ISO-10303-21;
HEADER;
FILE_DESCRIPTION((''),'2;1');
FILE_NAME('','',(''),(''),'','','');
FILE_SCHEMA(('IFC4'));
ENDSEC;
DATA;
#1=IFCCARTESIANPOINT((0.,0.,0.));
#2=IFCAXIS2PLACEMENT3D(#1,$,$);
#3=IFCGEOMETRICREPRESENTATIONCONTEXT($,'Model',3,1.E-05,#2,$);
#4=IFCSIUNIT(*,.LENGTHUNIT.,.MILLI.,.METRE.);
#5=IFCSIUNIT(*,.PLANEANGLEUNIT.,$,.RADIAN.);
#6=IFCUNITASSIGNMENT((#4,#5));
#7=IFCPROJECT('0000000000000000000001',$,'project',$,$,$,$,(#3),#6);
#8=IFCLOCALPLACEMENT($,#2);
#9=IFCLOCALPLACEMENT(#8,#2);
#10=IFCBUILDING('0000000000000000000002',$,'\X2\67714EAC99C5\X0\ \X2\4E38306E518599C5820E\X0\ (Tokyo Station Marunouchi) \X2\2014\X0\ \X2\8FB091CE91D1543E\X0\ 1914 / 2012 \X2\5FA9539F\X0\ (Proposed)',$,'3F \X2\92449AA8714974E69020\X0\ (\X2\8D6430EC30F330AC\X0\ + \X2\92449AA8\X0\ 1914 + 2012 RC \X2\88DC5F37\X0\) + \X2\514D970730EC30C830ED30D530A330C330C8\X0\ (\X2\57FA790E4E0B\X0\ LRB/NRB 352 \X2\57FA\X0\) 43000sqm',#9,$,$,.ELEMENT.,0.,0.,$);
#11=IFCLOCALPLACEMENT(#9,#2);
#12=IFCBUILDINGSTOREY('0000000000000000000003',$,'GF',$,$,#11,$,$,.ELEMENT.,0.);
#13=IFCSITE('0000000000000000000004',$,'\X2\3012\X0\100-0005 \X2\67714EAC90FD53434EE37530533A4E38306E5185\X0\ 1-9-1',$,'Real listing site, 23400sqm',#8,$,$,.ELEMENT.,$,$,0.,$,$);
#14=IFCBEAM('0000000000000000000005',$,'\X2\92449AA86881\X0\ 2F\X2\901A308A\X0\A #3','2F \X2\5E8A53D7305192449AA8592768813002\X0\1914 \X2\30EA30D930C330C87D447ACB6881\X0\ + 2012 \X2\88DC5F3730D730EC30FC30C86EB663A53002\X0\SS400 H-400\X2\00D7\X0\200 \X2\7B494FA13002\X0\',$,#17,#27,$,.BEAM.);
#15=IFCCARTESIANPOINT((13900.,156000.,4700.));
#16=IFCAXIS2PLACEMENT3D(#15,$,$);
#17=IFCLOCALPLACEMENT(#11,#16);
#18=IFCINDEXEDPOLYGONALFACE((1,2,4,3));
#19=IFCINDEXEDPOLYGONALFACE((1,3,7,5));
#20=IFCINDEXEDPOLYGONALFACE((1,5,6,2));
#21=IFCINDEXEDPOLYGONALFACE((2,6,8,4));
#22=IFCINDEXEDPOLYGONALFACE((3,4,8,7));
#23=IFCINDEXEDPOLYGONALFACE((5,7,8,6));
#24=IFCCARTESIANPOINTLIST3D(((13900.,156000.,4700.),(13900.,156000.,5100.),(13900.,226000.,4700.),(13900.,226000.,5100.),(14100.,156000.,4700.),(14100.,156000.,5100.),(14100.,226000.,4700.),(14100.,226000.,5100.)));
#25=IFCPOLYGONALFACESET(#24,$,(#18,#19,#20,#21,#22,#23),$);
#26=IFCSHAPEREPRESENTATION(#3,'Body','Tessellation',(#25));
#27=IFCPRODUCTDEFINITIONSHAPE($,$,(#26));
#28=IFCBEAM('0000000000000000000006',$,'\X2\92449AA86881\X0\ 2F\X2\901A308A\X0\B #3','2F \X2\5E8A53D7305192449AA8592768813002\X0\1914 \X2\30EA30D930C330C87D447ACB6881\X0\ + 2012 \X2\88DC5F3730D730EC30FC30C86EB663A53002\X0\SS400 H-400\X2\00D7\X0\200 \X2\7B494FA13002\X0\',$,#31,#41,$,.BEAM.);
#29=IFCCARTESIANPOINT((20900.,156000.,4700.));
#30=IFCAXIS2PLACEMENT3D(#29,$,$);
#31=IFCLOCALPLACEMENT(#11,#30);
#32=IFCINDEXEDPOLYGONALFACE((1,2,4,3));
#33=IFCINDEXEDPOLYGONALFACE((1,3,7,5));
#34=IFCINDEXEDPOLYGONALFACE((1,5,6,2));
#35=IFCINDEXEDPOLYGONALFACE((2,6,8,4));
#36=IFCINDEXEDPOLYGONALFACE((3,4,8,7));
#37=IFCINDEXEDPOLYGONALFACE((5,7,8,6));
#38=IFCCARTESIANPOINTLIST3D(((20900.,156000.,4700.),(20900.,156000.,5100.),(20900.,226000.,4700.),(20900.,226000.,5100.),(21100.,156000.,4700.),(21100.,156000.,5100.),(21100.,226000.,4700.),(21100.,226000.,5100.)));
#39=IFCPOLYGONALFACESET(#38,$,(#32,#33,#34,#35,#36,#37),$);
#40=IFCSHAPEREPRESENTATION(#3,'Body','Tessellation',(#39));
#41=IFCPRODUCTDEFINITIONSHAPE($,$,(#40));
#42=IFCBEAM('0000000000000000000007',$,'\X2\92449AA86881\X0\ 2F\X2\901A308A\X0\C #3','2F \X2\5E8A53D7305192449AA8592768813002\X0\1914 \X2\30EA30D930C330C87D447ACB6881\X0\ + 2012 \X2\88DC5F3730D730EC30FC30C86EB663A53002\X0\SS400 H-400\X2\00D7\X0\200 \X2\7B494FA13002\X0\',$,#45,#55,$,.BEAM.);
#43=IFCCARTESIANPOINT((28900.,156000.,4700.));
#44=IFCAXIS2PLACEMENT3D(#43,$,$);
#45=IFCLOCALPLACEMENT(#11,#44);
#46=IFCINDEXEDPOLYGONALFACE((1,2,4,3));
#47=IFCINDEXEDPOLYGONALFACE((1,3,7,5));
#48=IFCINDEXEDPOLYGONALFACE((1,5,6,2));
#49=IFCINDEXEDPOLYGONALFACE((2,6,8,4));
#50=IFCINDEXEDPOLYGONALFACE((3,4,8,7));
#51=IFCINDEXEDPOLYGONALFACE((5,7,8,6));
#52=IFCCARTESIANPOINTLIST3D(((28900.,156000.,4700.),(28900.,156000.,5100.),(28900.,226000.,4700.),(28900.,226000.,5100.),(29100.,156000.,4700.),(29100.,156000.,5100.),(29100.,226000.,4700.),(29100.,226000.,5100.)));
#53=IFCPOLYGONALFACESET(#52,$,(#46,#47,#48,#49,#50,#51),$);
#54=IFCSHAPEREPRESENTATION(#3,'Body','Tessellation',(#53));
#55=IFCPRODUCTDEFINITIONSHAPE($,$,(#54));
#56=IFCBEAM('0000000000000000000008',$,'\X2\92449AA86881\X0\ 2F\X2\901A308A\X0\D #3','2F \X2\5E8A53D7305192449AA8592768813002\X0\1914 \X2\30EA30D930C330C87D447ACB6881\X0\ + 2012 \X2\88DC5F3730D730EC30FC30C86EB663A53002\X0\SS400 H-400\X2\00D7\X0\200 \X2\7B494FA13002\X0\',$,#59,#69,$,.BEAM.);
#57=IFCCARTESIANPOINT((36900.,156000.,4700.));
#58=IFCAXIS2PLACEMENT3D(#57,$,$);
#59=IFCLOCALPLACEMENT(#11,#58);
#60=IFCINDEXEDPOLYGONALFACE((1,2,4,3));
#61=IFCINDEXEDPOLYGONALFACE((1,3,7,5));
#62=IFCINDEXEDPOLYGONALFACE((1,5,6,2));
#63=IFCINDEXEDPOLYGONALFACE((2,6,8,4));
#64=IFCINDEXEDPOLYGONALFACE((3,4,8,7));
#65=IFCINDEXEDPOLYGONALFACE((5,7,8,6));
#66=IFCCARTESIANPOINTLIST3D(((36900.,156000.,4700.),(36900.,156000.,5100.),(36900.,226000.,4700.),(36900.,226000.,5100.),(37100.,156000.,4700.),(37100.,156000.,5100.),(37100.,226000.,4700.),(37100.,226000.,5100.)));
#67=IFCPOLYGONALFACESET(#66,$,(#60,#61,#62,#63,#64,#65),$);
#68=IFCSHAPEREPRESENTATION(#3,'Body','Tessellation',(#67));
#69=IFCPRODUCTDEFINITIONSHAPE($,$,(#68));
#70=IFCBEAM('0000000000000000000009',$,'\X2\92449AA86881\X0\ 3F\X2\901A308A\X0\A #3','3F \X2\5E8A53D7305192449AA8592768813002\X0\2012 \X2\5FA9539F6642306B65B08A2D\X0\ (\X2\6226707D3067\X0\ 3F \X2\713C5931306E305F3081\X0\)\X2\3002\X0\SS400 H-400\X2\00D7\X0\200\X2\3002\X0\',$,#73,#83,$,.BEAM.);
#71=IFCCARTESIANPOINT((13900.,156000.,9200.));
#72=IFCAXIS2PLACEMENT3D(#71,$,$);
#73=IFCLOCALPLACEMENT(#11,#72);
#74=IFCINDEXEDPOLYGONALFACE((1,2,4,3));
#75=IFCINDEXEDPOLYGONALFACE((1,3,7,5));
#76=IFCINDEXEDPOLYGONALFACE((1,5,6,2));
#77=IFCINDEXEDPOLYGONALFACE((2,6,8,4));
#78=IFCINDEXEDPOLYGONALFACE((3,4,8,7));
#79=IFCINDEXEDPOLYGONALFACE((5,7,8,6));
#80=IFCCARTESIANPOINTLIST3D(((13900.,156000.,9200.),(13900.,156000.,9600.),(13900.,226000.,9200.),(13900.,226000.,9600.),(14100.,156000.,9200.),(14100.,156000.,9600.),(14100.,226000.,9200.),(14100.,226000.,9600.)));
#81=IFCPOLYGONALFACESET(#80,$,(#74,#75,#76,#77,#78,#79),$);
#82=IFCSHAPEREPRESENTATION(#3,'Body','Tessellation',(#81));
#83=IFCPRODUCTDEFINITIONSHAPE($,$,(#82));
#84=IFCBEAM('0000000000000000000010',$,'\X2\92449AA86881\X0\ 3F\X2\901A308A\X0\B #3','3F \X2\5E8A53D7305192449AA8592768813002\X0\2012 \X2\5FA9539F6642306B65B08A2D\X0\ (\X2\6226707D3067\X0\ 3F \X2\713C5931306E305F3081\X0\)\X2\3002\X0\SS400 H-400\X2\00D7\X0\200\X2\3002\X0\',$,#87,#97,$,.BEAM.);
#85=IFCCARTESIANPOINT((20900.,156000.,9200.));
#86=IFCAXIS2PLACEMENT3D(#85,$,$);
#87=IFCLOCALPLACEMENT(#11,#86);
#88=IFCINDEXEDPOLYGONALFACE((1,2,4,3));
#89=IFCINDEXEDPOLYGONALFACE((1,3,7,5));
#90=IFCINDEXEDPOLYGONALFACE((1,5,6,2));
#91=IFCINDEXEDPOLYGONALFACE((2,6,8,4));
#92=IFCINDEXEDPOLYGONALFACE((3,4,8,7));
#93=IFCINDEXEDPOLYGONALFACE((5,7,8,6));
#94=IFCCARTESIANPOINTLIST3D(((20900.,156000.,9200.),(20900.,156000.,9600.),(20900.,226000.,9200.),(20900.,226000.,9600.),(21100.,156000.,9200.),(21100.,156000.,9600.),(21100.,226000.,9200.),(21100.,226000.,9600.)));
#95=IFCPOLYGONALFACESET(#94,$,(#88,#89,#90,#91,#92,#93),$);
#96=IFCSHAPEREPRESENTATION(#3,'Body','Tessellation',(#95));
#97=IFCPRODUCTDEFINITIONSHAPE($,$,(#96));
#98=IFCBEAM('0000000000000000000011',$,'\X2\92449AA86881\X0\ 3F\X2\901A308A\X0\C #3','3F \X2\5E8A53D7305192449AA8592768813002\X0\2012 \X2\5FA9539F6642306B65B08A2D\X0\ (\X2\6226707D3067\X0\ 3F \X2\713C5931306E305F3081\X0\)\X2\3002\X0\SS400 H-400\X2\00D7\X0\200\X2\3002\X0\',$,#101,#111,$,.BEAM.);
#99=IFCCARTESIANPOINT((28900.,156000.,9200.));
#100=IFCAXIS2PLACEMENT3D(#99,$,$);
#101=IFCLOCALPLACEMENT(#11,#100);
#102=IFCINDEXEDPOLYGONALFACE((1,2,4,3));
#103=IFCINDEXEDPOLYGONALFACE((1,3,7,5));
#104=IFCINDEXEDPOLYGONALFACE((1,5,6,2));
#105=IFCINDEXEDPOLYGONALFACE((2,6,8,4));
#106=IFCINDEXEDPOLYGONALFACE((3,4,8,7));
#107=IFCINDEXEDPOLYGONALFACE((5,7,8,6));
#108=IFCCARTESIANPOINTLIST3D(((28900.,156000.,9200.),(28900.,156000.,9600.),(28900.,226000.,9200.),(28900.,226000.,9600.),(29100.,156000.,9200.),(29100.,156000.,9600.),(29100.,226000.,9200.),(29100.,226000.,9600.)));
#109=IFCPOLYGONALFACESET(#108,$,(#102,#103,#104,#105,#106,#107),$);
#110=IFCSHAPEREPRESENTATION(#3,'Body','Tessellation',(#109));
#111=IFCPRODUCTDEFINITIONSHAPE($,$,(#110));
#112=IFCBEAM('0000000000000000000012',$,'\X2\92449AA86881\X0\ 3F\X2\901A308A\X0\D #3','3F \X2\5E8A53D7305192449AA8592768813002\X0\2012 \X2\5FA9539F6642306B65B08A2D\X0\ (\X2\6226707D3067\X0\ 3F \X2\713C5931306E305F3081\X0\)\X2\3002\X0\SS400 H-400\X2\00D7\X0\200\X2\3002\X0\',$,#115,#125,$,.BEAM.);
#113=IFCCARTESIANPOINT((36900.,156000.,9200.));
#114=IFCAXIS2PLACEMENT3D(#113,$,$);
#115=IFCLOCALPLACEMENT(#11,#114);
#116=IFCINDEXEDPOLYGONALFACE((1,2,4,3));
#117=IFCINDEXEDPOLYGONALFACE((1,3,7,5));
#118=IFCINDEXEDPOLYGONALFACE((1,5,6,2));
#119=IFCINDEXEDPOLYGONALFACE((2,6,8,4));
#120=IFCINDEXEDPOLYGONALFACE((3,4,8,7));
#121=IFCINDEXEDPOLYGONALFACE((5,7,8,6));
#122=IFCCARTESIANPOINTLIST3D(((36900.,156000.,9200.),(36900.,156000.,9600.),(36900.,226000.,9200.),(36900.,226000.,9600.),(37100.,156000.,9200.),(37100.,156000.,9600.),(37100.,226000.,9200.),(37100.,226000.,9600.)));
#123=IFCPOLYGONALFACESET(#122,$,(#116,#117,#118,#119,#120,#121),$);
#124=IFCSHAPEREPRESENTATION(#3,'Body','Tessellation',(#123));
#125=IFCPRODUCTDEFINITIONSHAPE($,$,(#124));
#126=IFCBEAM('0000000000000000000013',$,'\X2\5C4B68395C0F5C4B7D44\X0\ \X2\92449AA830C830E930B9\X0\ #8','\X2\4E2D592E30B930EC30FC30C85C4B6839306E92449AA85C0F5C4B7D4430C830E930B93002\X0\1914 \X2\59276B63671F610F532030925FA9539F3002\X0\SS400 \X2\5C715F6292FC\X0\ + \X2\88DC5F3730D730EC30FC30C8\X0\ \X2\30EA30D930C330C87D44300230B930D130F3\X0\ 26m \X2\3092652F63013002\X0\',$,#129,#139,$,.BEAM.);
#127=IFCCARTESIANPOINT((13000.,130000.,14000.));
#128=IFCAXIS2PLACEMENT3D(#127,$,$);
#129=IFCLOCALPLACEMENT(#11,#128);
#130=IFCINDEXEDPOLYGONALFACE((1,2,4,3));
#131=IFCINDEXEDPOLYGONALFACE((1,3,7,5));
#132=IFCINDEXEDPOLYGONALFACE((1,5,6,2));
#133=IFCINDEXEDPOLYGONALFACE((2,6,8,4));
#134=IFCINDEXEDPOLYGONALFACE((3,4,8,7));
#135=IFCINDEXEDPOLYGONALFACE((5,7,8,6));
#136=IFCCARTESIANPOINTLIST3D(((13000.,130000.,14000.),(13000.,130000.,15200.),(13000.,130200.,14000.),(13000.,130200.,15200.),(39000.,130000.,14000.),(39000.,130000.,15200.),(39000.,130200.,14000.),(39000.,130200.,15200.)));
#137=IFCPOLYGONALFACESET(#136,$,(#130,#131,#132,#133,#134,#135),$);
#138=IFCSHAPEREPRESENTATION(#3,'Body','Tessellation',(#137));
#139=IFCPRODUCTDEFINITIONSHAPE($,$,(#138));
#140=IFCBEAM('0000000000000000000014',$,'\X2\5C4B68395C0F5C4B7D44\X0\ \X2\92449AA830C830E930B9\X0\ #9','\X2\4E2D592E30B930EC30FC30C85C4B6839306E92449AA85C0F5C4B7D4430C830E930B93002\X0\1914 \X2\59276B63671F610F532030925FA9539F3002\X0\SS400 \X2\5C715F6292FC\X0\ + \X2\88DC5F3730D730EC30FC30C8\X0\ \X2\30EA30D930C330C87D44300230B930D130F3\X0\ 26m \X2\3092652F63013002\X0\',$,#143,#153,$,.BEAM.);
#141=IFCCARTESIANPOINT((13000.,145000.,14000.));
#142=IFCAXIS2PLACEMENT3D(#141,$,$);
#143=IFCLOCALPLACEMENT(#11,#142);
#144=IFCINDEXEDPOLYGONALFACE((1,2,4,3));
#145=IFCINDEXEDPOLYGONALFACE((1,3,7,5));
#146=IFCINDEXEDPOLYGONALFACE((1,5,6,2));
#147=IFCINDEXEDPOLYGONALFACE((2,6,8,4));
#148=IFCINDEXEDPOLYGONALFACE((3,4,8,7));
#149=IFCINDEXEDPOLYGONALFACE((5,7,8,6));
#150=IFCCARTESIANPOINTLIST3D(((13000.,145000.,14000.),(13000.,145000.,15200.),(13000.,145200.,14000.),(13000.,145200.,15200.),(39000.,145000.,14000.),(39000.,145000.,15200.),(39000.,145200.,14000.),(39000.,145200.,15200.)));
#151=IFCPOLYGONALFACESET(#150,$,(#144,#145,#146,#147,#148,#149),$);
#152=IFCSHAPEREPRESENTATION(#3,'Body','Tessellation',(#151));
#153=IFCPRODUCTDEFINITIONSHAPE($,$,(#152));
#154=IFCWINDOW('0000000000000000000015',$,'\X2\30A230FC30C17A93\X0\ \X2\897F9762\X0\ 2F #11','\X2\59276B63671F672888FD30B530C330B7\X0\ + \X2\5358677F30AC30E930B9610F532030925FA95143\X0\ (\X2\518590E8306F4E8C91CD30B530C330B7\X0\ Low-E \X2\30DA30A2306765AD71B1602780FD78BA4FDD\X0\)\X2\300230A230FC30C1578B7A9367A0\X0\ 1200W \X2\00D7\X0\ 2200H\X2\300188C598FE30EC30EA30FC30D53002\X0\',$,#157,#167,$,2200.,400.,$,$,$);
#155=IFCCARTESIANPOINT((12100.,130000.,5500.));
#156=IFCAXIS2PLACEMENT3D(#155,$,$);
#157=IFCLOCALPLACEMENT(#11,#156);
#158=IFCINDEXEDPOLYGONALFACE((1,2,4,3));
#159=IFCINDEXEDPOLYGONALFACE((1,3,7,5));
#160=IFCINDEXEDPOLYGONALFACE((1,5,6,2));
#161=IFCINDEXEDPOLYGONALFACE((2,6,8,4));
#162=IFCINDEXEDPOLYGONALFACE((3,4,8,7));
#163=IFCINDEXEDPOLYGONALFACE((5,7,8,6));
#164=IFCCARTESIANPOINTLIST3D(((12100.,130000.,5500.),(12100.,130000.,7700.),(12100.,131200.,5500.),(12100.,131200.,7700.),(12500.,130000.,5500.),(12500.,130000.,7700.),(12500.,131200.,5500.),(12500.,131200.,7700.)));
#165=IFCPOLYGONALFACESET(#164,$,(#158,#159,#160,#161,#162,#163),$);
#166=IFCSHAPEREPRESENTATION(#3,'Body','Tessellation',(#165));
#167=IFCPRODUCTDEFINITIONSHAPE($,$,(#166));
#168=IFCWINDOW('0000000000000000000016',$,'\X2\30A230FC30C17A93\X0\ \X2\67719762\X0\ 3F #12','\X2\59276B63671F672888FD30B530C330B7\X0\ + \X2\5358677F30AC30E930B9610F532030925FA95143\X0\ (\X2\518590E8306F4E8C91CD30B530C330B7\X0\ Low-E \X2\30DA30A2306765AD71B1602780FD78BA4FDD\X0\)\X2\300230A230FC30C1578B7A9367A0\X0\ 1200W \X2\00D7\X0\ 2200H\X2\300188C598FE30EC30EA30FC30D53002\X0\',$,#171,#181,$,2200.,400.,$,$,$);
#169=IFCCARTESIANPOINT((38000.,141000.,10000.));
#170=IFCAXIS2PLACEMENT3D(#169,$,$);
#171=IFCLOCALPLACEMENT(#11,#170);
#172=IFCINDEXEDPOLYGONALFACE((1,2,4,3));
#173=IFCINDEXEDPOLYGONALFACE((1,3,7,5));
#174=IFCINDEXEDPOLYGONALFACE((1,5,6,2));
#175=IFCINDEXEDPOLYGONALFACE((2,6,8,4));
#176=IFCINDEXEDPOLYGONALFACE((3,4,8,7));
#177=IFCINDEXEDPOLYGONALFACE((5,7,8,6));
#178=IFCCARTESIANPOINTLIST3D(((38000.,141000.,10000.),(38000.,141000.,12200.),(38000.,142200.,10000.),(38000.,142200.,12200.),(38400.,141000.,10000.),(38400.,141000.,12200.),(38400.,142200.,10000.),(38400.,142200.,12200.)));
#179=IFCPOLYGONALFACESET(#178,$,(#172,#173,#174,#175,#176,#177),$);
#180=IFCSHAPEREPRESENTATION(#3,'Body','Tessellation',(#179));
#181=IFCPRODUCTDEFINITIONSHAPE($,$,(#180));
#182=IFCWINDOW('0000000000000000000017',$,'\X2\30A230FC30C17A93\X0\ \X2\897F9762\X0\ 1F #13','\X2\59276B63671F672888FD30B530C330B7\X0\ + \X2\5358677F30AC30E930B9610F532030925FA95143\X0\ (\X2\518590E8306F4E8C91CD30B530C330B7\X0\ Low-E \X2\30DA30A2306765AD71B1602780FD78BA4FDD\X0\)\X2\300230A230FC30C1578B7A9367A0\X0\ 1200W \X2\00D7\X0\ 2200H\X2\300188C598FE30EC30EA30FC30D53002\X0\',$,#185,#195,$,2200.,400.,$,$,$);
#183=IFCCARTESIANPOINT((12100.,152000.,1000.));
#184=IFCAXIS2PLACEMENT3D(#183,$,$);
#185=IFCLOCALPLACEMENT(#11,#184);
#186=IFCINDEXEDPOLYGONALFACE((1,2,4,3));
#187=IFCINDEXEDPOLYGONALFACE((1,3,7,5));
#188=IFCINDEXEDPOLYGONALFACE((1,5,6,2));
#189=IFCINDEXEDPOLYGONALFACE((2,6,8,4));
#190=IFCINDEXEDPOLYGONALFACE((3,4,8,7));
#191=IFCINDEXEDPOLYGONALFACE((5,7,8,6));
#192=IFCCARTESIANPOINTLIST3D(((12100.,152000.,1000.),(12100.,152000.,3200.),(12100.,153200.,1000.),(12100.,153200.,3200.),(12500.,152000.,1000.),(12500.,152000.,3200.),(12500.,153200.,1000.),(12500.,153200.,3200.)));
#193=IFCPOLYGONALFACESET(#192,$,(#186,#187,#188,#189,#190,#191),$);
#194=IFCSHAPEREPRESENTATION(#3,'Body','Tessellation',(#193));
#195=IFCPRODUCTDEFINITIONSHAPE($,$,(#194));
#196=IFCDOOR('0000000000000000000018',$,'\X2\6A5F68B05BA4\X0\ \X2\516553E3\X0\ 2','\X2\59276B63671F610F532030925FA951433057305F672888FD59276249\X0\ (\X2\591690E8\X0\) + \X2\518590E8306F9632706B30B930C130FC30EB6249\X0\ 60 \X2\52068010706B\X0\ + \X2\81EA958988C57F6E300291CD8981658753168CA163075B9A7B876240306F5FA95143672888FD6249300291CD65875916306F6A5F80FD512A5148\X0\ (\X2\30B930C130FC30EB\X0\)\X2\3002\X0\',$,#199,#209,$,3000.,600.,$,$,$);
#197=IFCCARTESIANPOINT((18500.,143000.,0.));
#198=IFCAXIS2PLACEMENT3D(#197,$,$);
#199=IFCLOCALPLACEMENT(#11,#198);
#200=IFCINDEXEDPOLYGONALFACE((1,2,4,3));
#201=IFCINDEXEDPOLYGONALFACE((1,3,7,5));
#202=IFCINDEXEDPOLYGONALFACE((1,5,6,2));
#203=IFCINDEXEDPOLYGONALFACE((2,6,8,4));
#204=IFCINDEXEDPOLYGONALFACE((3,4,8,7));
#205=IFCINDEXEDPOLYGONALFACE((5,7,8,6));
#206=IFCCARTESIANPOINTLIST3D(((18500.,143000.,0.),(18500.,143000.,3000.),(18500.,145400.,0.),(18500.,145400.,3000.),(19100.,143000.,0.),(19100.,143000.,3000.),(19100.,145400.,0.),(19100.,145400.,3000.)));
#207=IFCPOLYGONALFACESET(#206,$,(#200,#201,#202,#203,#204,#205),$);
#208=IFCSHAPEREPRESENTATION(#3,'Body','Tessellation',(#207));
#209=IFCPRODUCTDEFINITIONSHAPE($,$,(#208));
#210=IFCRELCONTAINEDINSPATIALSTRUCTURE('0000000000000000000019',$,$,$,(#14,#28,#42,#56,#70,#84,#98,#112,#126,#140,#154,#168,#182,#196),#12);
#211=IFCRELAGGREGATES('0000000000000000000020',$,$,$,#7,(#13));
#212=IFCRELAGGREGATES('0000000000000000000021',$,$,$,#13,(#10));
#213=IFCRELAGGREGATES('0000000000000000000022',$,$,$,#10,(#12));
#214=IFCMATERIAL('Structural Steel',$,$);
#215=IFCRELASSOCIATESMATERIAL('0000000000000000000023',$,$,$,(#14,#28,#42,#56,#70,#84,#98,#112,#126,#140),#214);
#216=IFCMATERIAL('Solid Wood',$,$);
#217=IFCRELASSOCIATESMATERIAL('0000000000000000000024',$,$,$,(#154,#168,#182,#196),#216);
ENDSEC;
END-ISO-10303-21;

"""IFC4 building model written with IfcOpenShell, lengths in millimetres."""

from ifc_helpers import new_model, si_unit, frame, frame_2d, origin, place, context, project, spatial, rectangle, extrude, material, element, save


model = new_model("IFC4")

# Units and contexts
model_context = context("Model", 3, precision=1e-05, world=origin())
ifc_project = project(units=[si_unit("LENGTHUNIT", "METRE", prefix="MILLI"), si_unit("PLANEANGLEUNIT", "RADIAN")], contexts=[model_context])

# Site, building, storey
site_placement = place(None, origin())
site = spatial("IfcSite", under=ifc_project, at=site_placement, Name="〒100-0005 東京都千代田区丸の内 1-9-1", ObjectType="Real listing site, 23400sqm", CompositionType="ELEMENT", RefElevation=0.0)
building_placement = place(site_placement, origin())
building = spatial("IfcBuilding", under=site, at=building_placement, Name="東京駅 丸の内駅舎 (Tokyo Station Marunouchi) — 辰野金吾 1914 / 2012 復原 (Proposed)", ObjectType="3F 鉄骨煉瓦造 (赤レンガ + 鉄骨 1914 + 2012 RC 補強) + 免震レトロフィット (基礎下 LRB/NRB 352 基) 43000sqm", CompositionType="ELEMENT", ElevationOfRefHeight=0.0, ElevationOfTerrain=0.0)
storey_placement = place(building_placement, origin())
storey = spatial("IfcBuildingStorey", under=building, at=storey_placement, Name="GF", CompositionType="ELEMENT", Elevation=0.0)

# Beams
ifc_material_1 = material(Name="Structural Steel")
beam_1_placement = place(storey_placement, frame((13900.0, 156000.0, 4700.0)))
element("IfcBeam", 1, at=beam_1_placement, inside=storey, material=ifc_material_1, Name="鉄骨梁 2F通りA #3", Description="2F 床受け鉄骨大梁。1914 リベット組立梁 + 2012 補強プレート溶接。SS400 H-400×200 等価。", PredefinedType="BEAM", context=model_context, shape_type="SweptSolid", body=[
    extrude(rectangle(XDim=200.0, YDim=70000.0, at=frame_2d((100.0, 35000.0))), frame((13900.0, 156000.0, 4700.0)), (0.0, 0.0, 1.0), 400.0),
])
beam_2_placement = place(storey_placement, frame((20900.0, 156000.0, 4700.0)))
element("IfcBeam", 2, at=beam_2_placement, inside=storey, material=ifc_material_1, Name="鉄骨梁 2F通りB #3", Description="2F 床受け鉄骨大梁。1914 リベット組立梁 + 2012 補強プレート溶接。SS400 H-400×200 等価。", PredefinedType="BEAM", context=model_context, shape_type="SweptSolid", body=[
    extrude(rectangle(XDim=200.0, YDim=70000.0, at=frame_2d((100.0, 35000.0))), frame((20900.0, 156000.0, 4700.0)), (0.0, 0.0, 1.0), 400.0),
])
beam_3_placement = place(storey_placement, frame((28900.0, 156000.0, 4700.0)))
element("IfcBeam", 3, at=beam_3_placement, inside=storey, material=ifc_material_1, Name="鉄骨梁 2F通りC #3", Description="2F 床受け鉄骨大梁。1914 リベット組立梁 + 2012 補強プレート溶接。SS400 H-400×200 等価。", PredefinedType="BEAM", context=model_context, shape_type="SweptSolid", body=[
    extrude(rectangle(XDim=200.0, YDim=70000.0, at=frame_2d((100.0, 35000.0))), frame((28900.0, 156000.0, 4700.0)), (0.0, 0.0, 1.0), 400.0),
])
beam_4_placement = place(storey_placement, frame((36900.0, 156000.0, 4700.0)))
element("IfcBeam", 4, at=beam_4_placement, inside=storey, material=ifc_material_1, Name="鉄骨梁 2F通りD #3", Description="2F 床受け鉄骨大梁。1914 リベット組立梁 + 2012 補強プレート溶接。SS400 H-400×200 等価。", PredefinedType="BEAM", context=model_context, shape_type="SweptSolid", body=[
    extrude(rectangle(XDim=200.0, YDim=70000.0, at=frame_2d((100.0, 35000.0))), frame((36900.0, 156000.0, 4700.0)), (0.0, 0.0, 1.0), 400.0),
])
beam_5_placement = place(storey_placement, frame((13900.0, 156000.0, 9200.0)))
element("IfcBeam", 5, at=beam_5_placement, inside=storey, material=ifc_material_1, Name="鉄骨梁 3F通りA #3", Description="3F 床受け鉄骨大梁。2012 復原時に新設 (戦災で 3F 焼失のため)。SS400 H-400×200。", PredefinedType="BEAM", context=model_context, shape_type="SweptSolid", body=[
    extrude(rectangle(XDim=200.0, YDim=70000.0, at=frame_2d((100.0, 35000.0))), frame((13900.0, 156000.0, 9200.0)), (0.0, 0.0, 1.0), 400.0),
])
beam_6_placement = place(storey_placement, frame((20900.0, 156000.0, 9200.0)))
element("IfcBeam", 6, at=beam_6_placement, inside=storey, material=ifc_material_1, Name="鉄骨梁 3F通りB #3", Description="3F 床受け鉄骨大梁。2012 復原時に新設 (戦災で 3F 焼失のため)。SS400 H-400×200。", PredefinedType="BEAM", context=model_context, shape_type="SweptSolid", body=[
    extrude(rectangle(XDim=200.0, YDim=70000.0, at=frame_2d((100.0, 35000.0))), frame((20900.0, 156000.0, 9200.0)), (0.0, 0.0, 1.0), 400.0),
])
beam_7_placement = place(storey_placement, frame((28900.0, 156000.0, 9200.0)))
element("IfcBeam", 7, at=beam_7_placement, inside=storey, material=ifc_material_1, Name="鉄骨梁 3F通りC #3", Description="3F 床受け鉄骨大梁。2012 復原時に新設 (戦災で 3F 焼失のため)。SS400 H-400×200。", PredefinedType="BEAM", context=model_context, shape_type="SweptSolid", body=[
    extrude(rectangle(XDim=200.0, YDim=70000.0, at=frame_2d((100.0, 35000.0))), frame((28900.0, 156000.0, 9200.0)), (0.0, 0.0, 1.0), 400.0),
])
beam_8_placement = place(storey_placement, frame((36900.0, 156000.0, 9200.0)))
element("IfcBeam", 8, at=beam_8_placement, inside=storey, material=ifc_material_1, Name="鉄骨梁 3F通りD #3", Description="3F 床受け鉄骨大梁。2012 復原時に新設 (戦災で 3F 焼失のため)。SS400 H-400×200。", PredefinedType="BEAM", context=model_context, shape_type="SweptSolid", body=[
    extrude(rectangle(XDim=200.0, YDim=70000.0, at=frame_2d((100.0, 35000.0))), frame((36900.0, 156000.0, 9200.0)), (0.0, 0.0, 1.0), 400.0),
])
beam_9_placement = place(storey_placement, frame((13000.0, 130000.0, 14000.0)))
element("IfcBeam", 9, at=beam_9_placement, inside=storey, material=ifc_material_1, Name="屋根小屋組 鉄骨トラス #8", Description="中央スレート屋根の鉄骨小屋組トラス。1914 大正期意匠を復原。SS400 山形鋼 + 補強プレート リベット組。スパン 26m を支持。", PredefinedType="BEAM", context=model_context, shape_type="SweptSolid", body=[
    extrude(rectangle(XDim=26000.0, YDim=200.0, at=frame_2d((13000.0, 100.0))), frame((13000.0, 130000.0, 14000.0)), (0.0, 0.0, 1.0), 1200.0),
])
beam_10_placement = place(storey_placement, frame((13000.0, 145000.0, 14000.0)))
element("IfcBeam", 10, at=beam_10_placement, inside=storey, material=ifc_material_1, Name="屋根小屋組 鉄骨トラス #9", Description="中央スレート屋根の鉄骨小屋組トラス。1914 大正期意匠を復原。SS400 山形鋼 + 補強プレート リベット組。スパン 26m を支持。", PredefinedType="BEAM", context=model_context, shape_type="SweptSolid", body=[
    extrude(rectangle(XDim=26000.0, YDim=200.0, at=frame_2d((13000.0, 100.0))), frame((13000.0, 145000.0, 14000.0)), (0.0, 0.0, 1.0), 1200.0),
])

# Windows
ifc_material_2 = material(Name="Solid Wood")
window_1_placement = place(storey_placement, frame((12100.0, 130000.0, 5500.0)))
element("IfcWindow", 11, at=window_1_placement, inside=storey, material=ifc_material_2, Name="アーチ窓 西面 2F #11", Description="大正期木製サッシ + 単板ガラス意匠を復元 (内部は二重サッシ Low-E ペアで断熱性能確保)。アーチ型窓枠 1200W × 2200H、装飾レリーフ。", OverallHeight=2200.0, OverallWidth=400.0, context=model_context, shape_type="SweptSolid", body=[
    extrude(rectangle(XDim=400.0, YDim=1200.0, at=frame_2d((200.0, 600.0))), frame((12100.0, 130000.0, 5500.0)), (0.0, 0.0, 1.0), 2200.0),
])
window_2_placement = place(storey_placement, frame((38000.0, 141000.0, 10000.0)))
element("IfcWindow", 12, at=window_2_placement, inside=storey, material=ifc_material_2, Name="アーチ窓 東面 3F #12", Description="大正期木製サッシ + 単板ガラス意匠を復元 (内部は二重サッシ Low-E ペアで断熱性能確保)。アーチ型窓枠 1200W × 2200H、装飾レリーフ。", OverallHeight=2200.0, OverallWidth=400.0, context=model_context, shape_type="SweptSolid", body=[
    extrude(rectangle(XDim=400.0, YDim=1200.0, at=frame_2d((200.0, 600.0))), frame((38000.0, 141000.0, 10000.0)), (0.0, 0.0, 1.0), 2200.0),
])
window_3_placement = place(storey_placement, frame((12100.0, 152000.0, 1000.0)))
element("IfcWindow", 13, at=window_3_placement, inside=storey, material=ifc_material_2, Name="アーチ窓 西面 1F #13", Description="大正期木製サッシ + 単板ガラス意匠を復元 (内部は二重サッシ Low-E ペアで断熱性能確保)。アーチ型窓枠 1200W × 2200H、装飾レリーフ。", OverallHeight=2200.0, OverallWidth=400.0, context=model_context, shape_type="SweptSolid", body=[
    extrude(rectangle(XDim=400.0, YDim=1200.0, at=frame_2d((200.0, 600.0))), frame((12100.0, 152000.0, 1000.0)), (0.0, 0.0, 1.0), 2200.0),
])

# Door
door_placement = place(storey_placement, frame((18500.0, 143000.0, 0.0)))
element("IfcDoor", 14, at=door_placement, inside=storey, material=ifc_material_2, Name="機械室 入口 2", Description="大正期意匠を復元した木製大扉 (外部) + 内部は防火スチール扉 60 分耐火 + 自閉装置。重要文化財指定箇所は復元木製扉。重文外は機能優先 (スチール)。", OverallHeight=3000.0, OverallWidth=600.0, context=model_context, shape_type="SweptSolid", body=[
    extrude(rectangle(XDim=600.0, YDim=2400.0, at=frame_2d((300.0, 1200.0))), frame((18500.0, 143000.0, 0.0)), (0.0, 0.0, 1.0), 3000.0),
])

save(model, "model.ifc")
